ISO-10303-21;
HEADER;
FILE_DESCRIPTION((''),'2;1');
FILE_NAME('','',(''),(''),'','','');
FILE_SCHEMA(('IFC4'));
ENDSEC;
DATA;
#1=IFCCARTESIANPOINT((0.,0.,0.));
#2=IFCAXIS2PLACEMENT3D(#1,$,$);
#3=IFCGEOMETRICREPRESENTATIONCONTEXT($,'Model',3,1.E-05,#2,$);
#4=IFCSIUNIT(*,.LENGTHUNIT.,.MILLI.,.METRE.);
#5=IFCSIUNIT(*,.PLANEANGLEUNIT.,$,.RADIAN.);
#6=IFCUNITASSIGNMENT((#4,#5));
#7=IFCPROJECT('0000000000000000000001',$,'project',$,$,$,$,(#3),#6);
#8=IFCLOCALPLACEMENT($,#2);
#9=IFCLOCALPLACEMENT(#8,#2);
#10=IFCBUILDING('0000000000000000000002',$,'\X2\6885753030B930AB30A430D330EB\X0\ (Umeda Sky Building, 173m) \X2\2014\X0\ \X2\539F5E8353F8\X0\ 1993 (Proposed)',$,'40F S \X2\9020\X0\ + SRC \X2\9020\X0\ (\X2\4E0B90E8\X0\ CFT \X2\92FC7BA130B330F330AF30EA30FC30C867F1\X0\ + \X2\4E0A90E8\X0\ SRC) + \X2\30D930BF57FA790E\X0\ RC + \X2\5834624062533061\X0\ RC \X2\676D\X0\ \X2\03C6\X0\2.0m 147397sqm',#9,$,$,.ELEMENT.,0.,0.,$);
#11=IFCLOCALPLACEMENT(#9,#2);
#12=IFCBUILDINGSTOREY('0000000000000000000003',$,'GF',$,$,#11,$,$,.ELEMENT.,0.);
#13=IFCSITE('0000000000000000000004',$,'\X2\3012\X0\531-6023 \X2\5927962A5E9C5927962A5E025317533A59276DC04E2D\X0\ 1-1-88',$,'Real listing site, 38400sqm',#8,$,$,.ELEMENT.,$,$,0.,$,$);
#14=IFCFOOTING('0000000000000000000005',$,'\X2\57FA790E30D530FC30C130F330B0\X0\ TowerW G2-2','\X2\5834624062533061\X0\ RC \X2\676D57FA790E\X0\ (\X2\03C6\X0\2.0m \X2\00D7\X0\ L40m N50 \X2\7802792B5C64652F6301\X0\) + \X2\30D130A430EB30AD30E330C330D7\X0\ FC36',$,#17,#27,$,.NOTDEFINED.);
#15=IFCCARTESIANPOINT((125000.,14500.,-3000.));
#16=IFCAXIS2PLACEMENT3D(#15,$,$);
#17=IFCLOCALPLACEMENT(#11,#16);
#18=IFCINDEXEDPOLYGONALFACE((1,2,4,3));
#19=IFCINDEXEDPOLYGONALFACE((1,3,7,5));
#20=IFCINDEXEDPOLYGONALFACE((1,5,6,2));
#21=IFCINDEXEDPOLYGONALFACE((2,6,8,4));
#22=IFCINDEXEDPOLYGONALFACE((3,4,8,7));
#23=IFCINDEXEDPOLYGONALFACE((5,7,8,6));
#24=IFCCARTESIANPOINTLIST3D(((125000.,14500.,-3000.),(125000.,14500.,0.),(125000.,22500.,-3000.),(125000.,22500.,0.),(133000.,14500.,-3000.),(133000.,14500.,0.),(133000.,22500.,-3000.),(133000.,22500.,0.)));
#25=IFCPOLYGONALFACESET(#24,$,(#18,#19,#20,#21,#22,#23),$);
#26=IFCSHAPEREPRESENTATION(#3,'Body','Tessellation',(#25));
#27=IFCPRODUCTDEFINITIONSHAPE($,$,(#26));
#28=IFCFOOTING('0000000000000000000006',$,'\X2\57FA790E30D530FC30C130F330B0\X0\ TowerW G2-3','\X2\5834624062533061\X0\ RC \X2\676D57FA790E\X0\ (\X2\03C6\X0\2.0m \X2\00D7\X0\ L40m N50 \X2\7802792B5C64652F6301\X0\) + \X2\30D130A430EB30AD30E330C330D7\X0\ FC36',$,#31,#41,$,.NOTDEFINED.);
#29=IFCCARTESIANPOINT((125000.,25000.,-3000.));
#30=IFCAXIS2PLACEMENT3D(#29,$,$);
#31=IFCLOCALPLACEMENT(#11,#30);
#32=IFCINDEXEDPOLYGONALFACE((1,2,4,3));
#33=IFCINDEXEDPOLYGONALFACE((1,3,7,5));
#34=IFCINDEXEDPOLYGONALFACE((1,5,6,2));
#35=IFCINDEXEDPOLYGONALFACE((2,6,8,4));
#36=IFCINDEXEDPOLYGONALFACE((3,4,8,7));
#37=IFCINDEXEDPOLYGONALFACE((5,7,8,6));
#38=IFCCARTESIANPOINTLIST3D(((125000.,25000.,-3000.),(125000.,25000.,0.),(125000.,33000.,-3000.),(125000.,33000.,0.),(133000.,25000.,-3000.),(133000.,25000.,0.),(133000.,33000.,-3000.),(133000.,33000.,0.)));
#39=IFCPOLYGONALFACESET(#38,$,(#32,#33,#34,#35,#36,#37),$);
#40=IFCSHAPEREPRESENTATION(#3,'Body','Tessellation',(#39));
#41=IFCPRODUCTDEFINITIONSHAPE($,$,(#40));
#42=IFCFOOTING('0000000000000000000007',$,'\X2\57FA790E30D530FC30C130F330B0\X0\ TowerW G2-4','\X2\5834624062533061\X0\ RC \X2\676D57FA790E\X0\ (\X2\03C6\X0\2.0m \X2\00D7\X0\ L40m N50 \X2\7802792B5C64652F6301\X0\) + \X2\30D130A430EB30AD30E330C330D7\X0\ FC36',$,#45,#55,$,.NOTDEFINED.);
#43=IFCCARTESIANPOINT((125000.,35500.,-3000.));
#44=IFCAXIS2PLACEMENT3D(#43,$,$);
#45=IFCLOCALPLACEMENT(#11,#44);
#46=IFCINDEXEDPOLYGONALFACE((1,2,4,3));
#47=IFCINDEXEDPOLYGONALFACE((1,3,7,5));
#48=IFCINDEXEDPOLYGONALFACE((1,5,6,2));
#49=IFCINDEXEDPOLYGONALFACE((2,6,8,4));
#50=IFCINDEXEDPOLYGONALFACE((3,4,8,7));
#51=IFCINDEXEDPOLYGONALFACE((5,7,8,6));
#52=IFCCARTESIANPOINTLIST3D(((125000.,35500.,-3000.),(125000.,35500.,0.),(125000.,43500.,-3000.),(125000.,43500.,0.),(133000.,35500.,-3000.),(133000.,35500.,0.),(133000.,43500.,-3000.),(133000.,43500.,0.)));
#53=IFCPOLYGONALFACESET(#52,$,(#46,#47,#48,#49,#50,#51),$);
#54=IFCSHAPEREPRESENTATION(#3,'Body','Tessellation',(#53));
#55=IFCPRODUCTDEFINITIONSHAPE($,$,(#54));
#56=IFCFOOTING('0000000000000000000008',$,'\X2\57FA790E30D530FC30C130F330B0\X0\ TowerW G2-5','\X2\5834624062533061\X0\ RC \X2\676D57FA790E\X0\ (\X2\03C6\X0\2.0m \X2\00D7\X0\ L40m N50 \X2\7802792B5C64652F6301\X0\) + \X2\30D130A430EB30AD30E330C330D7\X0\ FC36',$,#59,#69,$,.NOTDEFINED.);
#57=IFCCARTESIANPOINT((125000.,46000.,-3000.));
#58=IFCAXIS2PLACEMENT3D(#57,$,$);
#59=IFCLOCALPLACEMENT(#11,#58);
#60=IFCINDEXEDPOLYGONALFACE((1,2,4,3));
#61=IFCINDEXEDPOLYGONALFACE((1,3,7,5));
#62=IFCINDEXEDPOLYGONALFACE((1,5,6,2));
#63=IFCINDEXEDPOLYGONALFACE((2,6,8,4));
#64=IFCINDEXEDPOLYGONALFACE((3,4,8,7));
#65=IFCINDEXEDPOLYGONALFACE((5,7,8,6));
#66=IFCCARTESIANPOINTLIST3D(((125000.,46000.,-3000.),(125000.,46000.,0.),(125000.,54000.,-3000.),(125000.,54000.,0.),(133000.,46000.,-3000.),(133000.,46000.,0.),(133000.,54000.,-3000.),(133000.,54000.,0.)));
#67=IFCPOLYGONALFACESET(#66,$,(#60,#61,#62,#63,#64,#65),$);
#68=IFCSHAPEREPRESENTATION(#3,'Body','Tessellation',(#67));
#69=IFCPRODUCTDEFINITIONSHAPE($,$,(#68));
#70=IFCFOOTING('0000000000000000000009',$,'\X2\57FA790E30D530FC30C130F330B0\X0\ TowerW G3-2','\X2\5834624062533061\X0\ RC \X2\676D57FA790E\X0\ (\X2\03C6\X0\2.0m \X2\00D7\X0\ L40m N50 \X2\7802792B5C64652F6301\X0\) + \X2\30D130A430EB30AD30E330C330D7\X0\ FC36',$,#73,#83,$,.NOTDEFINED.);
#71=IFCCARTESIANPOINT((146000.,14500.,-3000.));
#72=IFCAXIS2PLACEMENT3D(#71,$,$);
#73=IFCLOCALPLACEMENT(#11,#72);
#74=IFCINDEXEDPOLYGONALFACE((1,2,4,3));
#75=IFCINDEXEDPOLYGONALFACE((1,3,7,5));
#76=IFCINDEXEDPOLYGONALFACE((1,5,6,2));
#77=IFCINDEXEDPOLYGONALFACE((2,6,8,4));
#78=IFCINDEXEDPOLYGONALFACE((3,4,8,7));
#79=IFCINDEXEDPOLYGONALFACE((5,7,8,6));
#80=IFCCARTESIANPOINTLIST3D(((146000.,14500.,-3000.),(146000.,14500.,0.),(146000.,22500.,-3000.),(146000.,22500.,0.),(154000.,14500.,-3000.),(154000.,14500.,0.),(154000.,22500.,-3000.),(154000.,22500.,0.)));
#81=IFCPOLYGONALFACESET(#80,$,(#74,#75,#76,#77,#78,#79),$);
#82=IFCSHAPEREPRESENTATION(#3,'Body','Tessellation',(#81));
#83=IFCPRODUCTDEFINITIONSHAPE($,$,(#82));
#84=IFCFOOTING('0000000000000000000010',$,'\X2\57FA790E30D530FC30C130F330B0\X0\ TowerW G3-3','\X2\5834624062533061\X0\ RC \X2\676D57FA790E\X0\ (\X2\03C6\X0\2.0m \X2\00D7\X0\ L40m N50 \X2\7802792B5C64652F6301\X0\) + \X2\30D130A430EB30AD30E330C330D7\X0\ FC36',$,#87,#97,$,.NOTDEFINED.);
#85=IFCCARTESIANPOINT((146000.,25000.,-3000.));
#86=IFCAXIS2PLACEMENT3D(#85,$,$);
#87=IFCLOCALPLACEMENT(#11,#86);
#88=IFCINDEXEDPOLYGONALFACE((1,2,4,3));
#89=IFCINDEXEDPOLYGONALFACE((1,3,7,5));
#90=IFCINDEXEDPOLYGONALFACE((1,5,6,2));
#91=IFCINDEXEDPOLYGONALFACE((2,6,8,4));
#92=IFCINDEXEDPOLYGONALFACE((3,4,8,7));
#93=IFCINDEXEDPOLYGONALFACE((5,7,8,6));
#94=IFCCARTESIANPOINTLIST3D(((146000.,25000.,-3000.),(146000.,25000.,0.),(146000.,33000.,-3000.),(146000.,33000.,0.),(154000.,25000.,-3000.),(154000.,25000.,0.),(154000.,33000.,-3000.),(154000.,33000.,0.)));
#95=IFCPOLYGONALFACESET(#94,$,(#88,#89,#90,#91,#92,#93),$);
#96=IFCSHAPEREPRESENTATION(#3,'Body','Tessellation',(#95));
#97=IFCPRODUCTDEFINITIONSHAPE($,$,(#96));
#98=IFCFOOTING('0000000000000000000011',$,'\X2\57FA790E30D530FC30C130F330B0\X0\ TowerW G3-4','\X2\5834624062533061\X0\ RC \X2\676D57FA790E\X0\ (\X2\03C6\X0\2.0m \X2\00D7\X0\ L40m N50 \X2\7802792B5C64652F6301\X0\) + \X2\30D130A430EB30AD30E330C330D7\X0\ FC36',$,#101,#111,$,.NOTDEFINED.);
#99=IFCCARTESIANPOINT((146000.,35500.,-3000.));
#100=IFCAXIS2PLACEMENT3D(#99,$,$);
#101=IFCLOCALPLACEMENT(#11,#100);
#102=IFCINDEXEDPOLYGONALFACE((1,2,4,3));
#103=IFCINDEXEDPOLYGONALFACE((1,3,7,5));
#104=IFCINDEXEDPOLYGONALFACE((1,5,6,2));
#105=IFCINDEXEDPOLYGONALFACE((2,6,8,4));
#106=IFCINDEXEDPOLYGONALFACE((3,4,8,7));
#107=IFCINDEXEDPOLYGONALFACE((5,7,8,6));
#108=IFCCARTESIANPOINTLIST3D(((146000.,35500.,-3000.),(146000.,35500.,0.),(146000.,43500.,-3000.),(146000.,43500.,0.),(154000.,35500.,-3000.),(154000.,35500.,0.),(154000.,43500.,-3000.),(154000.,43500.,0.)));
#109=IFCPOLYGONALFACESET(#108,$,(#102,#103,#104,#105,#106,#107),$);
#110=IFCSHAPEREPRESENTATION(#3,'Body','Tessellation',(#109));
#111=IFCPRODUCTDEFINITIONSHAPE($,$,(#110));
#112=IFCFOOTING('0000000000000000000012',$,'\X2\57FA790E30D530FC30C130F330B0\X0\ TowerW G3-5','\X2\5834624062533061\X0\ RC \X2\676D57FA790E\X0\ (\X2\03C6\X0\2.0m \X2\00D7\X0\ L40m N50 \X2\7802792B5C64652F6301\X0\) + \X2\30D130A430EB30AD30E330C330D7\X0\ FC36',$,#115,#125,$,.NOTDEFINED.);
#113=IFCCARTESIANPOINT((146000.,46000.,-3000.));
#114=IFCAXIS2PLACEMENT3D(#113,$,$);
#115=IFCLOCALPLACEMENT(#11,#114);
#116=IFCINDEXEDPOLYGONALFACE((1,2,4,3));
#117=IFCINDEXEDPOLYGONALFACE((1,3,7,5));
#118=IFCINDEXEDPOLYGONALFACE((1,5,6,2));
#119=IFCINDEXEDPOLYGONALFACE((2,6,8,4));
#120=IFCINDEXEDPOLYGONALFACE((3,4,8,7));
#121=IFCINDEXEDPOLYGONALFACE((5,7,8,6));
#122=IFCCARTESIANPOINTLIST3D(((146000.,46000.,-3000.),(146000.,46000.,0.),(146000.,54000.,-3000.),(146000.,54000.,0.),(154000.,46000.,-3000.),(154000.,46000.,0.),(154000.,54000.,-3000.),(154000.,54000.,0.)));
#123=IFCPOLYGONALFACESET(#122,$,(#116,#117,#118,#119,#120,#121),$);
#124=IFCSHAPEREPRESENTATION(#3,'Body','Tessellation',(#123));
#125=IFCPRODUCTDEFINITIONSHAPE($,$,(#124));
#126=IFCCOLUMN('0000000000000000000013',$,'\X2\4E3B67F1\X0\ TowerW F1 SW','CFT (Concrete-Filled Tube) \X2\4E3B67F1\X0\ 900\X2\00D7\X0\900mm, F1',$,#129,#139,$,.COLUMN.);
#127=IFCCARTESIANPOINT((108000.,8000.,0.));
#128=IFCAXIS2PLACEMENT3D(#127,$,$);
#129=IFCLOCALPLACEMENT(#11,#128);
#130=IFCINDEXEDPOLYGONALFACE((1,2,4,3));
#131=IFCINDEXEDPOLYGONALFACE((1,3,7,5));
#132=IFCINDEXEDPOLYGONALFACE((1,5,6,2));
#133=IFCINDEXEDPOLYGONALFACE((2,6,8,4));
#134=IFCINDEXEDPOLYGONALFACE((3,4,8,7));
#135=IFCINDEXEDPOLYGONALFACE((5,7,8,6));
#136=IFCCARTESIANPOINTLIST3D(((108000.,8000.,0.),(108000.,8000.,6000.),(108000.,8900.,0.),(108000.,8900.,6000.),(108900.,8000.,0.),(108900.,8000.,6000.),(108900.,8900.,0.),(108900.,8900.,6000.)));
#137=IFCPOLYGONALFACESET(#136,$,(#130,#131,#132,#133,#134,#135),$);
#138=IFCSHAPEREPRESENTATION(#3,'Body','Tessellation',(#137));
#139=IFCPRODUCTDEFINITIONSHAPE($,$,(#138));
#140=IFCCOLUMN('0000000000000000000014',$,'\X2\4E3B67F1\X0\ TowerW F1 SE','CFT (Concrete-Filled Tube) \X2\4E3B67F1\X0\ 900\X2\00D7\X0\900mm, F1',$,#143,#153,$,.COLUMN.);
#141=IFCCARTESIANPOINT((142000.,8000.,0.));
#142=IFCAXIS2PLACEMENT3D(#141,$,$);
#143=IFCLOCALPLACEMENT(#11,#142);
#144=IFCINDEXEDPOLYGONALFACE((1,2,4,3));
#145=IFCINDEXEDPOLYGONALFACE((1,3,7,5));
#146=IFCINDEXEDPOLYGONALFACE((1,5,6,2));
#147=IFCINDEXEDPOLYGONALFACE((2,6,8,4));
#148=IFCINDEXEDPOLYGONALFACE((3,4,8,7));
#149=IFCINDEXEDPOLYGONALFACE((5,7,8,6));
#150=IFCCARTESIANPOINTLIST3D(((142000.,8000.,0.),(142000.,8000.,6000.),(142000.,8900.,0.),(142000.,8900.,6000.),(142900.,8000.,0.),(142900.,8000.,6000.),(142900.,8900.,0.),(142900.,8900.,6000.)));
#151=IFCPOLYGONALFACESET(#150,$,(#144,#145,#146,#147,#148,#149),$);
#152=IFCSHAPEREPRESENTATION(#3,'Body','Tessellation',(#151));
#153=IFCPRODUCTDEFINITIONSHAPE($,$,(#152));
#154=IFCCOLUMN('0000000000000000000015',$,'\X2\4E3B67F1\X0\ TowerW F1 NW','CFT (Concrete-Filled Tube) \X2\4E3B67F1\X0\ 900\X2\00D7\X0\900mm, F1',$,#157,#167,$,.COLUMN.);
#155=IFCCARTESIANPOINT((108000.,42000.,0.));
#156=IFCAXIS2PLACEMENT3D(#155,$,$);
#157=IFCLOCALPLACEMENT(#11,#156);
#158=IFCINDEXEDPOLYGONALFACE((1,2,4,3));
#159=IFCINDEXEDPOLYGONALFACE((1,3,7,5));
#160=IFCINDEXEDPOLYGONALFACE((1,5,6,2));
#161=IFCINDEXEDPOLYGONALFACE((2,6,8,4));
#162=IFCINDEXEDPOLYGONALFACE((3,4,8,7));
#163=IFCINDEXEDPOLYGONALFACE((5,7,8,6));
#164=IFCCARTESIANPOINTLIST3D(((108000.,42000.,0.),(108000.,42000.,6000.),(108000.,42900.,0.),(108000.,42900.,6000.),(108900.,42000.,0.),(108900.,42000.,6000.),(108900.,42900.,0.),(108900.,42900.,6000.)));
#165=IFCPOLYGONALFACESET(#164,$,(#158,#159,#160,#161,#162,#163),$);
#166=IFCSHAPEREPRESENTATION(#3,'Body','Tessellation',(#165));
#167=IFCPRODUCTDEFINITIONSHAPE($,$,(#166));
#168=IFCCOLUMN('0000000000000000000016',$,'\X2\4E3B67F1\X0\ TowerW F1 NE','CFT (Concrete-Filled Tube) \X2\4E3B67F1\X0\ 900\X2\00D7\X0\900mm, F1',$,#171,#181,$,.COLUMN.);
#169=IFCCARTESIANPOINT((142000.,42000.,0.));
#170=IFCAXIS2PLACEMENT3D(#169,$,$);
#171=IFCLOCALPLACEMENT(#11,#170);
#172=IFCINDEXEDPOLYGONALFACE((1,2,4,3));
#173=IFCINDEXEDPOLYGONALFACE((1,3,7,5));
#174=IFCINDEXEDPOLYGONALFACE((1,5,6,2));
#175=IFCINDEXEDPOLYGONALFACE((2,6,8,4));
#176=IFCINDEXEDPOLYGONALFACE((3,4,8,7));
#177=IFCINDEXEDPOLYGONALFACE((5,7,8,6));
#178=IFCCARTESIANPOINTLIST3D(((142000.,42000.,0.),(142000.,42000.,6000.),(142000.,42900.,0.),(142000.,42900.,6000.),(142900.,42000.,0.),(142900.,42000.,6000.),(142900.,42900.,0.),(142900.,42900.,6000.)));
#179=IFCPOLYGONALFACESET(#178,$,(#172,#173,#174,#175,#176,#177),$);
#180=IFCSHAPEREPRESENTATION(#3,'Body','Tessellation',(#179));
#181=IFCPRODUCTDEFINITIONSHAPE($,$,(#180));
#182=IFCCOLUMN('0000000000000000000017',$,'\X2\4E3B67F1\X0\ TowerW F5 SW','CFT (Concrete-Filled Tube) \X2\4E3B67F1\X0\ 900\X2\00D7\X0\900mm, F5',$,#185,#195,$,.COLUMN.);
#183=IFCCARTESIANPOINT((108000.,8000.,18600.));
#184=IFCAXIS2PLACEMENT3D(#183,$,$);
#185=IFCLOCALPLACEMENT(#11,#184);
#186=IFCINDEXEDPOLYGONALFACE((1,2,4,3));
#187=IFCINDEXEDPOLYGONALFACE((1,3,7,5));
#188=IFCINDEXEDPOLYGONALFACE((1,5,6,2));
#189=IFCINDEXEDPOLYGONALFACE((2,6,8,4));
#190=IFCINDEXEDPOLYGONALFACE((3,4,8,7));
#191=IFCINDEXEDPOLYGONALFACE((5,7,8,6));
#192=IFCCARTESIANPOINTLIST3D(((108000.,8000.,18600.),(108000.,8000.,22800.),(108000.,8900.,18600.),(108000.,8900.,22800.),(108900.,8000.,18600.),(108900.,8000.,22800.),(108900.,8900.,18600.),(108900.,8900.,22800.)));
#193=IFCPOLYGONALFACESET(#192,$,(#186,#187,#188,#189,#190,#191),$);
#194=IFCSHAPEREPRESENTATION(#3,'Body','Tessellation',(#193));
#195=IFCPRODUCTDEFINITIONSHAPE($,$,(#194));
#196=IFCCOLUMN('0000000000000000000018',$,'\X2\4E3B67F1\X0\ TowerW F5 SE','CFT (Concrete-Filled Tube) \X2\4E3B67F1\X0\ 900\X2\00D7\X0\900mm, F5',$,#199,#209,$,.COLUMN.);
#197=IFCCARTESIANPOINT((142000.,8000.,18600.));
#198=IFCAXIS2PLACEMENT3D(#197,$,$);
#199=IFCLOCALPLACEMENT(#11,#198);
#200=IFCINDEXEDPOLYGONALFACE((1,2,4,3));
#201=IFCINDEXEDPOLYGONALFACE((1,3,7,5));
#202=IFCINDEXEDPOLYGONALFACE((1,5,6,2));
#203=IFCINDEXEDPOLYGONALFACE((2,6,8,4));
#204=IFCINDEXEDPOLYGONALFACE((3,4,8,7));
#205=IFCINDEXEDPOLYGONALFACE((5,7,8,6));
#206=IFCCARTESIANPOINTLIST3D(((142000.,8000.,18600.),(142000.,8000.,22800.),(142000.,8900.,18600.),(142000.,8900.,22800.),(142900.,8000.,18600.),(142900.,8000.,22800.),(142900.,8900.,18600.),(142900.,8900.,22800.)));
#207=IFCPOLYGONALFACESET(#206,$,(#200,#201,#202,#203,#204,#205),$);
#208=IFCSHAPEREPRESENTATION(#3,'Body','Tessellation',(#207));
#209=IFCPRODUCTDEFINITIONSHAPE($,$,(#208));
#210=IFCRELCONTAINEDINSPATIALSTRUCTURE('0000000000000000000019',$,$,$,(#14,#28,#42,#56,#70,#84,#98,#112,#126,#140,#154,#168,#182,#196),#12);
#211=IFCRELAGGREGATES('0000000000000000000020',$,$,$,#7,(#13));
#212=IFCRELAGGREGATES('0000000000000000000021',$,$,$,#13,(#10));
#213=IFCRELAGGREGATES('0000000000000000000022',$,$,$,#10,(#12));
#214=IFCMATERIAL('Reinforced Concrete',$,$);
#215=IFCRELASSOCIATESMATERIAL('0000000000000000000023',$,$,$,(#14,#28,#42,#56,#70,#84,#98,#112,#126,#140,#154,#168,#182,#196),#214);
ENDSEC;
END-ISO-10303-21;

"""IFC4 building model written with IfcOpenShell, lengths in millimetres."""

from ifc_helpers import new_model, si_unit, frame, frame_2d, origin, place, context, project, spatial, rectangle, extrude, material, element, save


model = new_model("IFC4")

# Units and contexts
model_context = context("Model", 3, precision=1e-05, world=origin())
ifc_project = project(units=[si_unit("LENGTHUNIT", "METRE", prefix="MILLI"), si_unit("PLANEANGLEUNIT", "RADIAN")], contexts=[model_context])

# Site, building, storey
site_placement = place(None, origin())
site = spatial("IfcSite", under=ifc_project, at=site_placement, Name="〒531-6023 大阪府大阪市北区大淀中 1-1-88", ObjectType="Real listing site, 38400sqm", CompositionType="ELEMENT", RefElevation=0.0)
building_placement = place(site_placement, origin())
building = spatial("IfcBuilding", under=site, at=building_placement, Name="梅田スカイビル (Umeda Sky Building, 173m) — 原広司 1993 (Proposed)", ObjectType="40F S 造 + SRC 造 (下部 CFT 鋼管コンクリート柱 + 上部 SRC) + ベタ基礎 RC + 場所打ち RC 杭 φ2.0m 147397sqm", CompositionType="ELEMENT", ElevationOfRefHeight=0.0, ElevationOfTerrain=0.0)
storey_placement = place(building_placement, origin())
storey = spatial("IfcBuildingStorey", under=building, at=storey_placement, Name="GF", CompositionType="ELEMENT", Elevation=0.0)

# Footings
ifc_material_1 = material(Name="Reinforced Concrete")
footing_1_placement = place(storey_placement, frame((125000.0, 14500.0, -3000.0)))
element("IfcFooting", 1, at=footing_1_placement, inside=storey, material=ifc_material_1, Name="基礎フーチング TowerW G2-2", Description="場所打ち RC 杭基礎 (φ2.0m × L40m N50 砂礫層支持) + パイルキャップ FC36", PredefinedType="NOTDEFINED", context=model_context, shape_type="SweptSolid", body=[
    extrude(rectangle(XDim=8000.0, YDim=8000.0, at=frame_2d((4000.0, 4000.0))), frame((125000.0, 14500.0, -3000.0)), (0.0, 0.0, 1.0), 3000.0),
])
footing_2_placement = place(storey_placement, frame((125000.0, 25000.0, -3000.0)))
element("IfcFooting", 2, at=footing_2_placement, inside=storey, material=ifc_material_1, Name="基礎フーチング TowerW G2-3", Description="場所打ち RC 杭基礎 (φ2.0m × L40m N50 砂礫層支持) + パイルキャップ FC36", PredefinedType="NOTDEFINED", context=model_context, shape_type="SweptSolid", body=[
    extrude(rectangle(XDim=8000.0, YDim=8000.0, at=frame_2d((4000.0, 4000.0))), frame((125000.0, 25000.0, -3000.0)), (0.0, 0.0, 1.0), 3000.0),
])
footing_3_placement = place(storey_placement, frame((125000.0, 35500.0, -3000.0)))
element("IfcFooting", 3, at=footing_3_placement, inside=storey, material=ifc_material_1, Name="基礎フーチング TowerW G2-4", Description="場所打ち RC 杭基礎 (φ2.0m × L40m N50 砂礫層支持) + パイルキャップ FC36", PredefinedType="NOTDEFINED", context=model_context, shape_type="SweptSolid", body=[
    extrude(rectangle(XDim=8000.0, YDim=8000.0, at=frame_2d((4000.0, 4000.0))), frame((125000.0, 35500.0, -3000.0)), (0.0, 0.0, 1.0), 3000.0),
])
footing_4_placement = place(storey_placement, frame((125000.0, 46000.0, -3000.0)))
element("IfcFooting", 4, at=footing_4_placement, inside=storey, material=ifc_material_1, Name="基礎フーチング TowerW G2-5", Description="場所打ち RC 杭基礎 (φ2.0m × L40m N50 砂礫層支持) + パイルキャップ FC36", PredefinedType="NOTDEFINED", context=model_context, shape_type="SweptSolid", body=[
    extrude(rectangle(XDim=8000.0, YDim=8000.0, at=frame_2d((4000.0, 4000.0))), frame((125000.0, 46000.0, -3000.0)), (0.0, 0.0, 1.0), 3000.0),
])
footing_5_placement = place(storey_placement, frame((146000.0, 14500.0, -3000.0)))
element("IfcFooting", 5, at=footing_5_placement, inside=storey, material=ifc_material_1, Name="基礎フーチング TowerW G3-2", Description="場所打ち RC 杭基礎 (φ2.0m × L40m N50 砂礫層支持) + パイルキャップ FC36", PredefinedType="NOTDEFINED", context=model_context, shape_type="SweptSolid", body=[
    extrude(rectangle(XDim=8000.0, YDim=8000.0, at=frame_2d((4000.0, 4000.0))), frame((146000.0, 14500.0, -3000.0)), (0.0, 0.0, 1.0), 3000.0),
])
footing_6_placement = place(storey_placement, frame((146000.0, 25000.0, -3000.0)))
element("IfcFooting", 6, at=footing_6_placement, inside=storey, material=ifc_material_1, Name="基礎フーチング TowerW G3-3", Description="場所打ち RC 杭基礎 (φ2.0m × L40m N50 砂礫層支持) + パイルキャップ FC36", PredefinedType="NOTDEFINED", context=model_context, shape_type="SweptSolid", body=[
    extrude(rectangle(XDim=8000.0, YDim=8000.0, at=frame_2d((4000.0, 4000.0))), frame((146000.0, 25000.0, -3000.0)), (0.0, 0.0, 1.0), 3000.0),
])
footing_7_placement = place(storey_placement, frame((146000.0, 35500.0, -3000.0)))
element("IfcFooting", 7, at=footing_7_placement, inside=storey, material=ifc_material_1, Name="基礎フーチング TowerW G3-4", Description="場所打ち RC 杭基礎 (φ2.0m × L40m N50 砂礫層支持) + パイルキャップ FC36", PredefinedType="NOTDEFINED", context=model_context, shape_type="SweptSolid", body=[
    extrude(rectangle(XDim=8000.0, YDim=8000.0, at=frame_2d((4000.0, 4000.0))), frame((146000.0, 35500.0, -3000.0)), (0.0, 0.0, 1.0), 3000.0),
])
footing_8_placement = place(storey_placement, frame((146000.0, 46000.0, -3000.0)))
element("IfcFooting", 8, at=footing_8_placement, inside=storey, material=ifc_material_1, Name="基礎フーチング TowerW G3-5", Description="場所打ち RC 杭基礎 (φ2.0m × L40m N50 砂礫層支持) + パイルキャップ FC36", PredefinedType="NOTDEFINED", context=model_context, shape_type="SweptSolid", body=[
    extrude(rectangle(XDim=8000.0, YDim=8000.0, at=frame_2d((4000.0, 4000.0))), frame((146000.0, 46000.0, -3000.0)), (0.0, 0.0, 1.0), 3000.0),
])

# Columns
column_1_placement = place(storey_placement, frame((108000.0, 8000.0, 0.0)))
element("IfcColumn", 9, at=column_1_placement, inside=storey, material=ifc_material_1, Name="主柱 TowerW F1 SW", Description="CFT (Concrete-Filled Tube) 主柱 900×900mm, F1", PredefinedType="COLUMN", context=model_context, shape_type="SweptSolid", body=[
    extrude(rectangle(XDim=900.0, YDim=900.0, at=frame_2d((450.0, 450.0))), frame((108000.0, 8000.0, 0.0)), (0.0, 0.0, 1.0), 6000.0),
])
column_2_placement = place(storey_placement, frame((142000.0, 8000.0, 0.0)))
element("IfcColumn", 10, at=column_2_placement, inside=storey, material=ifc_material_1, Name="主柱 TowerW F1 SE", Description="CFT (Concrete-Filled Tube) 主柱 900×900mm, F1", PredefinedType="COLUMN", context=model_context, shape_type="SweptSolid", body=[
    extrude(rectangle(XDim=900.0, YDim=900.0, at=frame_2d((450.0, 450.0))), frame((142000.0, 8000.0, 0.0)), (0.0, 0.0, 1.0), 6000.0),
])
column_3_placement = place(storey_placement, frame((108000.0, 42000.0, 0.0)))
element("IfcColumn", 11, at=column_3_placement, inside=storey, material=ifc_material_1, Name="主柱 TowerW F1 NW", Description="CFT (Concrete-Filled Tube) 主柱 900×900mm, F1", PredefinedType="COLUMN", context=model_context, shape_type="SweptSolid", body=[
    extrude(rectangle(XDim=900.0, YDim=900.0, at=frame_2d((450.0, 450.0))), frame((108000.0, 42000.0, 0.0)), (0.0, 0.0, 1.0), 6000.0),
])
column_4_placement = place(storey_placement, frame((142000.0, 42000.0, 0.0)))
element("IfcColumn", 12, at=column_4_placement, inside=storey, material=ifc_material_1, Name="主柱 TowerW F1 NE", Description="CFT (Concrete-Filled Tube) 主柱 900×900mm, F1", PredefinedType="COLUMN", context=model_context, shape_type="SweptSolid", body=[
    extrude(rectangle(XDim=900.0, YDim=900.0, at=frame_2d((450.0, 450.0))), frame((142000.0, 42000.0, 0.0)), (0.0, 0.0, 1.0), 6000.0),
])
column_5_placement = place(storey_placement, frame((108000.0, 8000.0, 18600.0)))
element("IfcColumn", 13, at=column_5_placement, inside=storey, material=ifc_material_1, Name="主柱 TowerW F5 SW", Description="CFT (Concrete-Filled Tube) 主柱 900×900mm, F5", PredefinedType="COLUMN", context=model_context, shape_type="SweptSolid", body=[
    extrude(rectangle(XDim=900.0, YDim=900.0, at=frame_2d((450.0, 450.0))), frame((108000.0, 8000.0, 18600.0)), (0.0, 0.0, 1.0), 4200.0),
])
column_6_placement = place(storey_placement, frame((142000.0, 8000.0, 18600.0)))
element("IfcColumn", 14, at=column_6_placement, inside=storey, material=ifc_material_1, Name="主柱 TowerW F5 SE", Description="CFT (Concrete-Filled Tube) 主柱 900×900mm, F5", PredefinedType="COLUMN", context=model_context, shape_type="SweptSolid", body=[
    extrude(rectangle(XDim=900.0, YDim=900.0, at=frame_2d((450.0, 450.0))), frame((142000.0, 8000.0, 18600.0)), (0.0, 0.0, 1.0), 4200.0),
])

save(model, "model.ifc")
